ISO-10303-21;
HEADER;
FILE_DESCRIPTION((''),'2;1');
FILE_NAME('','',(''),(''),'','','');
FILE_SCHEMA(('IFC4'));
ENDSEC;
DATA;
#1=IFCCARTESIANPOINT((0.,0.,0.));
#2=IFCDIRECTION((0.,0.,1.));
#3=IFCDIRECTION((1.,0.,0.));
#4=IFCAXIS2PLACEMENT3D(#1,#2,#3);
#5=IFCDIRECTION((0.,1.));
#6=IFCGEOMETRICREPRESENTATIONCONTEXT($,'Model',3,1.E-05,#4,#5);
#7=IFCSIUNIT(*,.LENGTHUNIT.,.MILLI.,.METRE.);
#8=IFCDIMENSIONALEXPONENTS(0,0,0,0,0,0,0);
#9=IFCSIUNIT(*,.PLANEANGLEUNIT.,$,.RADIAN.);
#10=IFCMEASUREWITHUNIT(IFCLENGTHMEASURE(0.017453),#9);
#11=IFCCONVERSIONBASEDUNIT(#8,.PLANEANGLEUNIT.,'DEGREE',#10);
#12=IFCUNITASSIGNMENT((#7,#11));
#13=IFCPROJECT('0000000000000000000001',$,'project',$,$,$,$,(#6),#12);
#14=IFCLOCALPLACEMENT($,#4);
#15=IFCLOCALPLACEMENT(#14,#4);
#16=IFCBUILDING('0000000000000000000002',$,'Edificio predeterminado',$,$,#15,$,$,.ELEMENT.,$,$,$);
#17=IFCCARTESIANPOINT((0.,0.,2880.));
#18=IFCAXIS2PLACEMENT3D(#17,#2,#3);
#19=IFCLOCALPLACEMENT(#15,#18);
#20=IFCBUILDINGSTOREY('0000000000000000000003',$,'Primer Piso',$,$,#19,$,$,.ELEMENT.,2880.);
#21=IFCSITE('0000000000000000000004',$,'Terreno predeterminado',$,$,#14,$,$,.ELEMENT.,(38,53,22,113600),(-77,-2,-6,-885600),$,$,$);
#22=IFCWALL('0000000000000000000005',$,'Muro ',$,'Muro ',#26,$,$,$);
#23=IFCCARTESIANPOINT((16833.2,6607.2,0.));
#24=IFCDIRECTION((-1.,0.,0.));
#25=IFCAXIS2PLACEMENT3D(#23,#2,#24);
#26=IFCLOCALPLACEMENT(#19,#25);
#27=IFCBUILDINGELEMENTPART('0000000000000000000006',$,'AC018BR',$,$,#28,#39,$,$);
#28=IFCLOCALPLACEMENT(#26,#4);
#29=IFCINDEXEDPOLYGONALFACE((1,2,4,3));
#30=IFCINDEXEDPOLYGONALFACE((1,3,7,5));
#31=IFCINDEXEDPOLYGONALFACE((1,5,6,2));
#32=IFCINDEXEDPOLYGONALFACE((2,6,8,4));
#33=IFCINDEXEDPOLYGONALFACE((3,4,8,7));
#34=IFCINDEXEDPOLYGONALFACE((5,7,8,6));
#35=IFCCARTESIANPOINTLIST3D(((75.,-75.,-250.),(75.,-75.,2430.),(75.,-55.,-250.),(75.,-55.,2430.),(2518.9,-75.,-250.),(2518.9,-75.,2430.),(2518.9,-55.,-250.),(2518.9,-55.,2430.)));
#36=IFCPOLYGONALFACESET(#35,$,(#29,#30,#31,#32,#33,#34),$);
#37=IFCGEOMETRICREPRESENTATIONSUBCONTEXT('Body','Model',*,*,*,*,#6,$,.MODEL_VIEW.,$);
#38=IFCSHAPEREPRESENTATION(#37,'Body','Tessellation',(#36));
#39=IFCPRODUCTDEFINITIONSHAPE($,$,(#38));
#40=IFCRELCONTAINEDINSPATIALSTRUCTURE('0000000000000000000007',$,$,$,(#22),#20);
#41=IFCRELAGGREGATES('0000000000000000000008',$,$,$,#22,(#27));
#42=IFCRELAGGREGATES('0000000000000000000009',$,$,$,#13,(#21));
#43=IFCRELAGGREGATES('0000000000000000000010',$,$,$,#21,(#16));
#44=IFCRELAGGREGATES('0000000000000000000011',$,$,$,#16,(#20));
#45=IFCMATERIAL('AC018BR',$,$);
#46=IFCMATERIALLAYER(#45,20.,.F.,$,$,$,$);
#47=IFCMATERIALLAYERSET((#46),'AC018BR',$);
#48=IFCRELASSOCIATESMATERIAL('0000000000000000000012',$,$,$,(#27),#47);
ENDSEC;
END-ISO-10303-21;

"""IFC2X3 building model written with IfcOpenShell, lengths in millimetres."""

from ifc_helpers import new_model, entity, si_unit, converted_unit, direction, frame, origin_with_axes, place, context, subcontext, project, spatial, polyline, outline, extrude, material, layer, layer_set, layer_usage, element, aggregate, save


model = new_model("IFC2X3")

# Units and contexts
model_context = context("Model", 3, precision=1e-05, world=origin_with_axes(), true_north=direction((0.0, 1.0)))
body_context = subcontext(model_context, "Body", "Model", "MODEL_VIEW")
ifc_project = project(units=[si_unit("LENGTHUNIT", "METRE", prefix="MILLI"), converted_unit("PLANEANGLEUNIT", "DEGREE", entity("IfcLengthMeasure", 0.017453), si_unit("PLANEANGLEUNIT", "RADIAN"), dimensions=[0, 0, 0, 0, 0, 0, 0])], contexts=[model_context])

# Site, building, storey
site_placement = place(None, origin_with_axes())
site = spatial("IfcSite", under=ifc_project, at=site_placement, Name="Terreno predeterminado", CompositionType="ELEMENT", RefLatitude=(38, 53, 22, 113600), RefLongitude=(-77, -2, -6, -885600))
building_placement = place(site_placement, origin_with_axes())
building = spatial("IfcBuilding", under=site, at=building_placement, Name="Edificio predeterminado", CompositionType="ELEMENT")
storey_placement = place(building_placement, frame((0.0, 0.0, 2880.0), z_axis=(0.0, 0.0, 1.0), x_axis=(1.0, 0.0, 0.0)))
storey = spatial("IfcBuildingStorey", under=building, at=storey_placement, Name="Primer Piso", CompositionType="ELEMENT", Elevation=2880.0)

# Wall, building element part
wall_1_placement = place(storey_placement, frame((16833.2, 6607.2, 0.0), z_axis=(0.0, 0.0, 1.0), x_axis=(-1.0, 0.0, 0.0)))
wall_1 = element("IfcWall", 1, at=wall_1_placement, inside=storey, Name="Muro ", ObjectType="Muro ")
ifc_material_1 = material(Name="AC018BR")
ifc_layer_1 = layer(ifc_material_1, 20.0, ventilated=False)
ifc_layer_set_1 = layer_set([ifc_layer_1], Name="AC018BR")
ifc_layer_usage_1 = layer_usage(ifc_layer_set_1, "AXIS2", "NEGATIVE", 55.0)
building_element_part_1_placement = place(wall_1_placement, origin_with_axes())
building_element_part_1 = element("IfcBuildingElementPart", 2, at=building_element_part_1_placement, material=ifc_layer_usage_1, Name="AC018BR", context=body_context, shape_type="SweptSolid", body=[
    extrude(outline(polyline([(2518.9, -55.0), (2518.9, -75.0), (75.0, -75.0), (75.0, -55.0), (2518.9, -55.0)])), frame((0.0, 0.0, -250.0), z_axis=(0.0, 0.0, 1.0), x_axis=(1.0, 0.0, 0.0)), (0.0, 0.0, 1.0), 2680.0),
])
aggregate(wall_1, [building_element_part_1])

save(model, "model.ifc")
